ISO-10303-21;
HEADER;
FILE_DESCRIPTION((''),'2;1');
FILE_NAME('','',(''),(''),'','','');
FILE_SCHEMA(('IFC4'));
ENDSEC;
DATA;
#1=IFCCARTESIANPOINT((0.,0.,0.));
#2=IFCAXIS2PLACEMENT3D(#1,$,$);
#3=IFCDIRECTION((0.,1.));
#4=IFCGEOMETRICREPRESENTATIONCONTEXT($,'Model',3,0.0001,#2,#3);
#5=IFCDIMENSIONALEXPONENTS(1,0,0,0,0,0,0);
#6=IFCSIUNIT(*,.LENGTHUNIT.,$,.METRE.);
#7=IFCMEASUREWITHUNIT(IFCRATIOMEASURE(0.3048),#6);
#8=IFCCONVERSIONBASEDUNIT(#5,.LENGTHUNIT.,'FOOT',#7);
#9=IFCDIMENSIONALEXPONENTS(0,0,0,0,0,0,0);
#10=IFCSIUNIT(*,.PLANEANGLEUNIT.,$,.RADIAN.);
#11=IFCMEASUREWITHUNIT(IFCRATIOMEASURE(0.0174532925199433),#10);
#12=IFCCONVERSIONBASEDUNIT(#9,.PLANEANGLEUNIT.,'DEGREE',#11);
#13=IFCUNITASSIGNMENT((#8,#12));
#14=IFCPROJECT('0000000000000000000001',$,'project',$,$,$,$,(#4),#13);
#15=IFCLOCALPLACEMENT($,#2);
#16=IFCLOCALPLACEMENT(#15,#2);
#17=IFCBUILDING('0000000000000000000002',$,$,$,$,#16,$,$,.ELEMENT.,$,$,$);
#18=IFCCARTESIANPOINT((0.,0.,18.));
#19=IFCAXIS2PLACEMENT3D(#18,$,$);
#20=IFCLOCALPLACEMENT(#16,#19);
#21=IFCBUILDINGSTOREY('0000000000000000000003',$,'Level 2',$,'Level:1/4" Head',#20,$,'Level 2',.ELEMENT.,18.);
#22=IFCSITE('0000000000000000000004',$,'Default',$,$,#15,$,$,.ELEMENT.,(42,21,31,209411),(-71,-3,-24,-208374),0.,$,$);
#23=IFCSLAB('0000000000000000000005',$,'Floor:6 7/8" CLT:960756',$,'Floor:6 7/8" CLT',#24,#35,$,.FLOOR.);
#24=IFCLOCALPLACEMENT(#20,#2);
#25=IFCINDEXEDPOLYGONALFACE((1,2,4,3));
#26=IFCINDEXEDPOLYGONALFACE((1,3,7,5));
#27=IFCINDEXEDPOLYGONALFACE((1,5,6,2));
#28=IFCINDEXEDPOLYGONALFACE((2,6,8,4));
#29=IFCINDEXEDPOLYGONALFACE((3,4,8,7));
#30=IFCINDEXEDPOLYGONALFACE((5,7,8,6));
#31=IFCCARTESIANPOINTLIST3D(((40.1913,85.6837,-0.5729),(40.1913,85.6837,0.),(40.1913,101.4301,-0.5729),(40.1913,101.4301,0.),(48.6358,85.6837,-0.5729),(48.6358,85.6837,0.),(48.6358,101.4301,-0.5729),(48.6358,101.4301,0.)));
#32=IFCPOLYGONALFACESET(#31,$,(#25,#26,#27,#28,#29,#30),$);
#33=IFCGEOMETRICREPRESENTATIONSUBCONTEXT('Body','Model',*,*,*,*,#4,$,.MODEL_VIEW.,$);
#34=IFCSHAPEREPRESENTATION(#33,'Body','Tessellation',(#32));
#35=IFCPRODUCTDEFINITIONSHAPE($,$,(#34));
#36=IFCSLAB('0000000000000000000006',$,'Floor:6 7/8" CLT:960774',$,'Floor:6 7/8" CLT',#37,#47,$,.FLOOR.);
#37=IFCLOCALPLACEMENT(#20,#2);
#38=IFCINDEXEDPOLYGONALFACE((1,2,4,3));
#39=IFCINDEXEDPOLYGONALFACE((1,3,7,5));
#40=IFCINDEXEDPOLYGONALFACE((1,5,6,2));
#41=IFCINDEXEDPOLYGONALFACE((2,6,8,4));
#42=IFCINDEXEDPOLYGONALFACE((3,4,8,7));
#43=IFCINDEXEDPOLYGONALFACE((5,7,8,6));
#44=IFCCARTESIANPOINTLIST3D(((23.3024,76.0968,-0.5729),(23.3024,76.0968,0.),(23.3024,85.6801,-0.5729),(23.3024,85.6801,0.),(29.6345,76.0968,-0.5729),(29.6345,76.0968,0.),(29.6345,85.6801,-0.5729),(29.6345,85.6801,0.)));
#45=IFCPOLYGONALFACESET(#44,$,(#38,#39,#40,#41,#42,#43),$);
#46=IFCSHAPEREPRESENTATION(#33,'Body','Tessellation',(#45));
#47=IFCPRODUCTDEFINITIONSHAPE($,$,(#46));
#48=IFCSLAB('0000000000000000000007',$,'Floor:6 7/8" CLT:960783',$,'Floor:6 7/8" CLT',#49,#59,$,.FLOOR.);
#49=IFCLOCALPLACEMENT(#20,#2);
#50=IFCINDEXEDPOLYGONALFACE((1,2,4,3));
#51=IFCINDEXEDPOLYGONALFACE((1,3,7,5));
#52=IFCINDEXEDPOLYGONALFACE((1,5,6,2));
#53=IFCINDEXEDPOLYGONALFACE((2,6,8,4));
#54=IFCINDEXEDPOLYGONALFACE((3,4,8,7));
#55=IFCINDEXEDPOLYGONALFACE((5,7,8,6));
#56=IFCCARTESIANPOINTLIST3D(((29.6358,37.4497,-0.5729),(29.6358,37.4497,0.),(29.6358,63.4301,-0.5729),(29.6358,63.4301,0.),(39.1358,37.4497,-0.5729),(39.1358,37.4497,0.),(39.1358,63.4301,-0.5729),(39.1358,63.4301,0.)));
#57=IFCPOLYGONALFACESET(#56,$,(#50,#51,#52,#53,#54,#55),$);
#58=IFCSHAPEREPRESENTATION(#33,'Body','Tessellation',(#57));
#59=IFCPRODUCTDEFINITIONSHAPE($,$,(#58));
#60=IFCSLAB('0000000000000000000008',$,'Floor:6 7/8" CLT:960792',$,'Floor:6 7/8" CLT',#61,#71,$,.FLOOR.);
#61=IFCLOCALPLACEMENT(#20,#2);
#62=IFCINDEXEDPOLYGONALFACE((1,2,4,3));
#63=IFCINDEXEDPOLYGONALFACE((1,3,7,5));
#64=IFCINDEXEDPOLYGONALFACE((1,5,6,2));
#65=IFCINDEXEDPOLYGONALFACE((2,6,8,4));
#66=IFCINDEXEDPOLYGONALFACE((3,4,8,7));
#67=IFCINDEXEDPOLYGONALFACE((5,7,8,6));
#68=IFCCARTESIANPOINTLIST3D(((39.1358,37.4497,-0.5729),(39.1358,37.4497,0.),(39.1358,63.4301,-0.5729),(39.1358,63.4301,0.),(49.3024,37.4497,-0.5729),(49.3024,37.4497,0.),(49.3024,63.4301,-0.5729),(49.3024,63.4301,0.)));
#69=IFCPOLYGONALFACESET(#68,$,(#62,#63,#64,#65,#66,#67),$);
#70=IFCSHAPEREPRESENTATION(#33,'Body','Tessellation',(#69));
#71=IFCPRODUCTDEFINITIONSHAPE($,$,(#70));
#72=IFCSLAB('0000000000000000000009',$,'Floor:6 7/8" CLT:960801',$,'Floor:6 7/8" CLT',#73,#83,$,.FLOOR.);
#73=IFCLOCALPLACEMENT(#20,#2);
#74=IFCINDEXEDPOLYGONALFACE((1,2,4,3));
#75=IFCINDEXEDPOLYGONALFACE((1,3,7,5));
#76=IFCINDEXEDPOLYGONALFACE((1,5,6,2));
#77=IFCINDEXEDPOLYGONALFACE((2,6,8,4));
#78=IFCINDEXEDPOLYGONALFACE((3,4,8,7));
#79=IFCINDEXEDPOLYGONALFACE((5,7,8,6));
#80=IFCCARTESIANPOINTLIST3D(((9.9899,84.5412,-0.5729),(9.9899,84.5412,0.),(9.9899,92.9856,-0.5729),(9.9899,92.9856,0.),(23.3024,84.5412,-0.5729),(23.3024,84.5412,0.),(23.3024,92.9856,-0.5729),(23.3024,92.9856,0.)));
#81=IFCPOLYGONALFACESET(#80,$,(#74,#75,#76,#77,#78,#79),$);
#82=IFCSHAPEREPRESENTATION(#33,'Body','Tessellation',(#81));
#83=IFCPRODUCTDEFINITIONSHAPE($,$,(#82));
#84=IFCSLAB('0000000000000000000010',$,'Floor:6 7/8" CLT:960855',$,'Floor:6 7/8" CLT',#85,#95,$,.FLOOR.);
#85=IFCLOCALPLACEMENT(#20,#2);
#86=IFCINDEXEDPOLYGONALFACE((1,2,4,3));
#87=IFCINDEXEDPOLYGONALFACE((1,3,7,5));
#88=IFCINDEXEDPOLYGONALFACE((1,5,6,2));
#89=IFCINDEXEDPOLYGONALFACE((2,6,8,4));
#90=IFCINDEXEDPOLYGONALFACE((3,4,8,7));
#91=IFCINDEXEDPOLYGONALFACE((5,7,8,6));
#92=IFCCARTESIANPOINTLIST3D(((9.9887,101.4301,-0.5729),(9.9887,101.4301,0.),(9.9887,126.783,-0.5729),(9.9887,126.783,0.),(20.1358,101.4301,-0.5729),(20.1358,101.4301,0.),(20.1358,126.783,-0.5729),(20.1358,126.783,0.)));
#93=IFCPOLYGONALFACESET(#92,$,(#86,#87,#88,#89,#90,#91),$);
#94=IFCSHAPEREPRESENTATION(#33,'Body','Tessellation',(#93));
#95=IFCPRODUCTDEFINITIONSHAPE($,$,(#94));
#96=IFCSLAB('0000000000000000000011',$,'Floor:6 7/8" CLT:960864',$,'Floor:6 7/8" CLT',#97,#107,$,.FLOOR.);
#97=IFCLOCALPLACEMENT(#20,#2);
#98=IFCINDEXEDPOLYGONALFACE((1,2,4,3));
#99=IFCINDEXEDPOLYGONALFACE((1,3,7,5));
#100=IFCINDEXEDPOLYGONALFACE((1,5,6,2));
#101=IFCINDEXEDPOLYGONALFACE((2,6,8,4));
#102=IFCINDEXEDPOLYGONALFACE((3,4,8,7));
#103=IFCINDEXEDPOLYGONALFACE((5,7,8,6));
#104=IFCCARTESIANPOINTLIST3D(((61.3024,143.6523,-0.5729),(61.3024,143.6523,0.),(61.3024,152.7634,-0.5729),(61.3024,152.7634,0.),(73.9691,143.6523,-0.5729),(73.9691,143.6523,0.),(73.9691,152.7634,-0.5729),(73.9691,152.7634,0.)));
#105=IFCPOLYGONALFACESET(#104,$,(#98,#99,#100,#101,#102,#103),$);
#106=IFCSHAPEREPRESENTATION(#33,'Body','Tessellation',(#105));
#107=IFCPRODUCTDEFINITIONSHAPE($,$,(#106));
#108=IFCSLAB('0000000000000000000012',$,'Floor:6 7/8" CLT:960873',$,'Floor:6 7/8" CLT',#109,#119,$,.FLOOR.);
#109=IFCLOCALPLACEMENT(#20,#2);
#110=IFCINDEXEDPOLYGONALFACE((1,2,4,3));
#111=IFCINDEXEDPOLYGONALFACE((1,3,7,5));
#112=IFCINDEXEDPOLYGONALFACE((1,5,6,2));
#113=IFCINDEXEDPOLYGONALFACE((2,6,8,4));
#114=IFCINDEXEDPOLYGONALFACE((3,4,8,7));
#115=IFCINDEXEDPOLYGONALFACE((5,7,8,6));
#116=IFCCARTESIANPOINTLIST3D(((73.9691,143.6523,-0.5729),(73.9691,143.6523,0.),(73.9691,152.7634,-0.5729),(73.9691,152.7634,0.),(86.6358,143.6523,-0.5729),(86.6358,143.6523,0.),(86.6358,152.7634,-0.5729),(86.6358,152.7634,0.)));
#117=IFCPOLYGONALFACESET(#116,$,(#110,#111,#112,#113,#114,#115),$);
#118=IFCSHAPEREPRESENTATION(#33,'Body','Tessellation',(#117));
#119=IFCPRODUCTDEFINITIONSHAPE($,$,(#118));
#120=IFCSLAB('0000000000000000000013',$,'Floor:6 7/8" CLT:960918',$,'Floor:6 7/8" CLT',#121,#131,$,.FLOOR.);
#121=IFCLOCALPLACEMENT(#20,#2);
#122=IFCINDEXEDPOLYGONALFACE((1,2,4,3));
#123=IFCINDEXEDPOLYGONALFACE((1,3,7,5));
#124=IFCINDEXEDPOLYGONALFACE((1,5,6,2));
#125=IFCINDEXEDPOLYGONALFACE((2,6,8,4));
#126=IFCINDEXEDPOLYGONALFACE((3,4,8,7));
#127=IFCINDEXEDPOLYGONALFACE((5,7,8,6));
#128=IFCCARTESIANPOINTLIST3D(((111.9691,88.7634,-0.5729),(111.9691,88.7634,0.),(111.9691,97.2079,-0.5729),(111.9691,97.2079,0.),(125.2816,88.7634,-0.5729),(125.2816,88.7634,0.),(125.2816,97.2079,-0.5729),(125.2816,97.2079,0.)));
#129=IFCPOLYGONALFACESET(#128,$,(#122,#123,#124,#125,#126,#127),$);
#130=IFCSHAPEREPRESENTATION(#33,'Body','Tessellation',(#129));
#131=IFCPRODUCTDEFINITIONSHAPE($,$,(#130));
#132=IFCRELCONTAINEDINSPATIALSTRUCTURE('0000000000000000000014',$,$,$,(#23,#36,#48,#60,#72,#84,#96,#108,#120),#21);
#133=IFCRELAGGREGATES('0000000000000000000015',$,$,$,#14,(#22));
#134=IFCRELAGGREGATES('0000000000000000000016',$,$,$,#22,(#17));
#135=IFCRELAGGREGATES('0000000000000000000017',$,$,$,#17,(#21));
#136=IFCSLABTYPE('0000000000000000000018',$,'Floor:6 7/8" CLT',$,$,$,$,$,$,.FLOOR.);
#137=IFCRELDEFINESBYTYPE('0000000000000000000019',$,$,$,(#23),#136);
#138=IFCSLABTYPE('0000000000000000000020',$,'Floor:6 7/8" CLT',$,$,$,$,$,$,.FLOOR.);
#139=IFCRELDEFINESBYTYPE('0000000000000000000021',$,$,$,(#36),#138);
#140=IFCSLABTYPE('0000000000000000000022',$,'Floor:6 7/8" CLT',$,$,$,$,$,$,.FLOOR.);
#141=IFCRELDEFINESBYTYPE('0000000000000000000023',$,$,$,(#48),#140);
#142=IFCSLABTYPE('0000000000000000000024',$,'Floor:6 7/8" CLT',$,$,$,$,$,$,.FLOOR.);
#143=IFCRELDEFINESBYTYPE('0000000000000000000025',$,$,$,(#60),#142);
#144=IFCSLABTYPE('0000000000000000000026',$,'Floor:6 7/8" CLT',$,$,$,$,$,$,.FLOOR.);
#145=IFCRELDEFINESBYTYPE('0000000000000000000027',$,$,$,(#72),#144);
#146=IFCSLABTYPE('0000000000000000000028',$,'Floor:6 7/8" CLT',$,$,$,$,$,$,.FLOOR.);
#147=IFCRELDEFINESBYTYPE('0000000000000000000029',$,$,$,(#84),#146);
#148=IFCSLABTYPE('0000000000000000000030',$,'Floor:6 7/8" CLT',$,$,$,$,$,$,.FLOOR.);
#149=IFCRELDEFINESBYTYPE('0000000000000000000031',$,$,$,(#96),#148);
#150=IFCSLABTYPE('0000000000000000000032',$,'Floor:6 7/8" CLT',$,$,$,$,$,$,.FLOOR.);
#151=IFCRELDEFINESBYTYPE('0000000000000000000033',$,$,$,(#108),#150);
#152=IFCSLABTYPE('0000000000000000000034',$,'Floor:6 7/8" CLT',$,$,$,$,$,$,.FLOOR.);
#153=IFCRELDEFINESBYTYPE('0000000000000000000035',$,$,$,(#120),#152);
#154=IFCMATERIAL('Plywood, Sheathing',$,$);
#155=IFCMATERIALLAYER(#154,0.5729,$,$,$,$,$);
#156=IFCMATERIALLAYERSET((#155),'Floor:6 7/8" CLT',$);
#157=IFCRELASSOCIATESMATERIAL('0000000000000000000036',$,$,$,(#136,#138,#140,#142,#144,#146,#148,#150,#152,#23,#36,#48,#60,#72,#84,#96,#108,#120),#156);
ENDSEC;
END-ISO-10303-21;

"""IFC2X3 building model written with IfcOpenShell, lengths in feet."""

from ifc_helpers import new_model, entity, si_unit, converted_unit, direction, frame, frame_2d, origin, origin_2d_with_axis, place, context, subcontext, project, spatial, rectangle, extrude, material, layer, layer_set, layer_usage, type_object, element, save


model = new_model("IFC2X3")

# Units and contexts
model_context = context("Model", 3, precision=0.0001, world=origin(), true_north=direction((0.0, 1.0)))
body_context = subcontext(model_context, "Body", "Model", "MODEL_VIEW")
ifc_project = project(units=[converted_unit("LENGTHUNIT", "FOOT", entity("IfcRatioMeasure", 0.3048), si_unit("LENGTHUNIT", "METRE"), dimensions=[1, 0, 0, 0, 0, 0, 0]), converted_unit("PLANEANGLEUNIT", "DEGREE", entity("IfcRatioMeasure", 0.0174532925199433), si_unit("PLANEANGLEUNIT", "RADIAN"), dimensions=[0, 0, 0, 0, 0, 0, 0])], contexts=[model_context])

# Site, building, storey
site_placement = place(None, origin())
site = spatial("IfcSite", under=ifc_project, at=site_placement, Name="Default", CompositionType="ELEMENT", RefLatitude=(42, 21, 31, 209411), RefLongitude=(-71, -3, -24, -208374), RefElevation=0.0)
building_placement = place(site_placement, origin())
building = spatial("IfcBuilding", under=site, at=building_placement, CompositionType="ELEMENT")
storey_placement = place(building_placement, frame((0.0, 0.0, 18.0)))
storey = spatial("IfcBuildingStorey", under=building, at=storey_placement, Name="Level 2", ObjectType="Level:1/4\" Head", LongName="Level 2", CompositionType="ELEMENT", Elevation=18.0)

# Slabs
ifc_material = material(Name="Plywood, Sheathing")
ifc_layer = layer(ifc_material, 0.5729)
ifc_layer_set = layer_set([ifc_layer], Name="Floor:6 7/8\" CLT")
ifc_layer_usage_1 = layer_usage(ifc_layer_set, "AXIS3", "POSITIVE", 0.0)
slab_type_1 = type_object("IfcSlabType", Name="Floor:6 7/8\" CLT", PredefinedType="FLOOR", material=ifc_layer_set)
slab_1_placement = place(storey_placement, origin())
element("IfcSlab", 1, at=slab_1_placement, inside=storey, type_object=slab_type_1, material=ifc_layer_usage_1, Name="Floor:6 7/8\" CLT:960756", ObjectType="Floor:6 7/8\" CLT", PredefinedType="FLOOR", context=body_context, shape_type="SweptSolid", body=[
    extrude(rectangle(XDim=15.7464, YDim=8.4444, at=frame_2d((0.0, 0.0), x_axis=(1.0, 0.0))), frame((44.4136, 93.5569, 0.0), z_axis=(0.0, 0.0, -1.0), x_axis=(0.0, 1.0, 0.0)), (0.0, 0.0, 1.0), 0.5729),
])
ifc_layer_usage_2 = layer_usage(ifc_layer_set, "AXIS3", "POSITIVE", 0.0)
slab_type_2 = type_object("IfcSlabType", Name="Floor:6 7/8\" CLT", PredefinedType="FLOOR", material=ifc_layer_set)
slab_2_placement = place(storey_placement, origin())
element("IfcSlab", 2, at=slab_2_placement, inside=storey, type_object=slab_type_2, material=ifc_layer_usage_2, Name="Floor:6 7/8\" CLT:960774", ObjectType="Floor:6 7/8\" CLT", PredefinedType="FLOOR", context=body_context, shape_type="SweptSolid", body=[
    extrude(rectangle(XDim=9.5833, YDim=6.3321, at=frame_2d((0.0, 0.0), x_axis=(1.0, 0.0))), frame((26.4685, 80.8884, 0.0), z_axis=(0.0, 0.0, -1.0), x_axis=(0.0, 1.0, 0.0)), (0.0, 0.0, 1.0), 0.5729),
])
ifc_layer_usage_3 = layer_usage(ifc_layer_set, "AXIS3", "POSITIVE", 0.0)
slab_type_3 = type_object("IfcSlabType", Name="Floor:6 7/8\" CLT", PredefinedType="FLOOR", material=ifc_layer_set)
slab_3_placement = place(storey_placement, origin())
element("IfcSlab", 3, at=slab_3_placement, inside=storey, type_object=slab_type_3, material=ifc_layer_usage_3, Name="Floor:6 7/8\" CLT:960783", ObjectType="Floor:6 7/8\" CLT", PredefinedType="FLOOR", context=body_context, shape_type="SweptSolid", body=[
    extrude(rectangle(XDim=25.9804, YDim=9.5, at=origin_2d_with_axis()), frame((34.3858, 50.4399, 0.0), z_axis=(0.0, 0.0, -1.0), x_axis=(0.0, 1.0, 0.0)), (0.0, 0.0, 1.0), 0.5729),
])
ifc_layer_usage_4 = layer_usage(ifc_layer_set, "AXIS3", "POSITIVE", 0.0)
slab_type_4 = type_object("IfcSlabType", Name="Floor:6 7/8\" CLT", PredefinedType="FLOOR", material=ifc_layer_set)
slab_4_placement = place(storey_placement, origin())
element("IfcSlab", 4, at=slab_4_placement, inside=storey, type_object=slab_type_4, material=ifc_layer_usage_4, Name="Floor:6 7/8\" CLT:960792", ObjectType="Floor:6 7/8\" CLT", PredefinedType="FLOOR", context=body_context, shape_type="SweptSolid", body=[
    extrude(rectangle(XDim=25.9804, YDim=10.1667, at=frame_2d((0.0, 0.0), x_axis=(1.0, 0.0))), frame((44.2191, 50.4399, 0.0), z_axis=(0.0, 0.0, -1.0), x_axis=(0.0, 1.0, 0.0)), (0.0, 0.0, 1.0), 0.5729),
])
ifc_layer_usage_5 = layer_usage(ifc_layer_set, "AXIS3", "POSITIVE", 0.0)
slab_type_5 = type_object("IfcSlabType", Name="Floor:6 7/8\" CLT", PredefinedType="FLOOR", material=ifc_layer_set)
slab_5_placement = place(storey_placement, origin())
element("IfcSlab", 5, at=slab_5_placement, inside=storey, type_object=slab_type_5, material=ifc_layer_usage_5, Name="Floor:6 7/8\" CLT:960801", ObjectType="Floor:6 7/8\" CLT", PredefinedType="FLOOR", context=body_context, shape_type="SweptSolid", body=[
    extrude(rectangle(XDim=8.4444, YDim=13.3125, at=frame_2d((0.0, 0.0), x_axis=(1.0, 0.0))), frame((16.6462, 88.7634, 0.0), z_axis=(0.0, 0.0, -1.0), x_axis=(0.0, 1.0, 0.0)), (0.0, 0.0, 1.0), 0.5729),
])
ifc_layer_usage_6 = layer_usage(ifc_layer_set, "AXIS3", "POSITIVE", 0.0)
slab_type_6 = type_object("IfcSlabType", Name="Floor:6 7/8\" CLT", PredefinedType="FLOOR", material=ifc_layer_set)
slab_6_placement = place(storey_placement, origin())
element("IfcSlab", 6, at=slab_6_placement, inside=storey, type_object=slab_type_6, material=ifc_layer_usage_6, Name="Floor:6 7/8\" CLT:960855", ObjectType="Floor:6 7/8\" CLT", PredefinedType="FLOOR", context=body_context, shape_type="SweptSolid", body=[
    extrude(rectangle(XDim=25.3529, YDim=10.1471, at=origin_2d_with_axis()), frame((15.0622, 114.1065, 0.0), z_axis=(0.0, 0.0, -1.0), x_axis=(0.0, 1.0, 0.0)), (0.0, 0.0, 1.0), 0.5729),
])
ifc_layer_usage_7 = layer_usage(ifc_layer_set, "AXIS3", "POSITIVE", 0.0)
slab_type_7 = type_object("IfcSlabType", Name="Floor:6 7/8\" CLT", PredefinedType="FLOOR", material=ifc_layer_set)
slab_7_placement = place(storey_placement, origin())
element("IfcSlab", 7, at=slab_7_placement, inside=storey, type_object=slab_type_7, material=ifc_layer_usage_7, Name="Floor:6 7/8\" CLT:960864", ObjectType="Floor:6 7/8\" CLT", PredefinedType="FLOOR", context=body_context, shape_type="SweptSolid", body=[
    extrude(rectangle(XDim=9.1111, YDim=12.6667, at=frame_2d((0.0, 0.0), x_axis=(1.0, 0.0))), frame((67.6358, 148.2079, 0.0), z_axis=(0.0, 0.0, -1.0), x_axis=(0.0, 1.0, 0.0)), (0.0, 0.0, 1.0), 0.5729),
])
ifc_layer_usage_8 = layer_usage(ifc_layer_set, "AXIS3", "POSITIVE", 0.0)
slab_type_8 = type_object("IfcSlabType", Name="Floor:6 7/8\" CLT", PredefinedType="FLOOR", material=ifc_layer_set)
slab_8_placement = place(storey_placement, origin())
element("IfcSlab", 8, at=slab_8_placement, inside=storey, type_object=slab_type_8, material=ifc_layer_usage_8, Name="Floor:6 7/8\" CLT:960873", ObjectType="Floor:6 7/8\" CLT", PredefinedType="FLOOR", context=body_context, shape_type="SweptSolid", body=[
    extrude(rectangle(XDim=9.1111, YDim=12.6667, at=frame_2d((0.0, 0.0), x_axis=(1.0, 0.0))), frame((80.3024, 148.2079, 0.0), z_axis=(0.0, 0.0, -1.0), x_axis=(0.0, 1.0, 0.0)), (0.0, 0.0, 1.0), 0.5729),
])
ifc_layer_usage_9 = layer_usage(ifc_layer_set, "AXIS3", "POSITIVE", 0.0)
slab_type_9 = type_object("IfcSlabType", Name="Floor:6 7/8\" CLT", PredefinedType="FLOOR", material=ifc_layer_set)
slab_9_placement = place(storey_placement, origin())
element("IfcSlab", 9, at=slab_9_placement, inside=storey, type_object=slab_type_9, material=ifc_layer_usage_9, Name="Floor:6 7/8\" CLT:960918", ObjectType="Floor:6 7/8\" CLT", PredefinedType="FLOOR", context=body_context, shape_type="SweptSolid", body=[
    extrude(rectangle(XDim=8.4444, YDim=13.3125, at=frame_2d((0.0, 0.0), x_axis=(1.0, 0.0))), frame((118.6254, 92.9856, 0.0), z_axis=(0.0, 0.0, -1.0), x_axis=(0.0, 1.0, 0.0)), (0.0, 0.0, 1.0), 0.5729),
])

save(model, "model.ifc")
